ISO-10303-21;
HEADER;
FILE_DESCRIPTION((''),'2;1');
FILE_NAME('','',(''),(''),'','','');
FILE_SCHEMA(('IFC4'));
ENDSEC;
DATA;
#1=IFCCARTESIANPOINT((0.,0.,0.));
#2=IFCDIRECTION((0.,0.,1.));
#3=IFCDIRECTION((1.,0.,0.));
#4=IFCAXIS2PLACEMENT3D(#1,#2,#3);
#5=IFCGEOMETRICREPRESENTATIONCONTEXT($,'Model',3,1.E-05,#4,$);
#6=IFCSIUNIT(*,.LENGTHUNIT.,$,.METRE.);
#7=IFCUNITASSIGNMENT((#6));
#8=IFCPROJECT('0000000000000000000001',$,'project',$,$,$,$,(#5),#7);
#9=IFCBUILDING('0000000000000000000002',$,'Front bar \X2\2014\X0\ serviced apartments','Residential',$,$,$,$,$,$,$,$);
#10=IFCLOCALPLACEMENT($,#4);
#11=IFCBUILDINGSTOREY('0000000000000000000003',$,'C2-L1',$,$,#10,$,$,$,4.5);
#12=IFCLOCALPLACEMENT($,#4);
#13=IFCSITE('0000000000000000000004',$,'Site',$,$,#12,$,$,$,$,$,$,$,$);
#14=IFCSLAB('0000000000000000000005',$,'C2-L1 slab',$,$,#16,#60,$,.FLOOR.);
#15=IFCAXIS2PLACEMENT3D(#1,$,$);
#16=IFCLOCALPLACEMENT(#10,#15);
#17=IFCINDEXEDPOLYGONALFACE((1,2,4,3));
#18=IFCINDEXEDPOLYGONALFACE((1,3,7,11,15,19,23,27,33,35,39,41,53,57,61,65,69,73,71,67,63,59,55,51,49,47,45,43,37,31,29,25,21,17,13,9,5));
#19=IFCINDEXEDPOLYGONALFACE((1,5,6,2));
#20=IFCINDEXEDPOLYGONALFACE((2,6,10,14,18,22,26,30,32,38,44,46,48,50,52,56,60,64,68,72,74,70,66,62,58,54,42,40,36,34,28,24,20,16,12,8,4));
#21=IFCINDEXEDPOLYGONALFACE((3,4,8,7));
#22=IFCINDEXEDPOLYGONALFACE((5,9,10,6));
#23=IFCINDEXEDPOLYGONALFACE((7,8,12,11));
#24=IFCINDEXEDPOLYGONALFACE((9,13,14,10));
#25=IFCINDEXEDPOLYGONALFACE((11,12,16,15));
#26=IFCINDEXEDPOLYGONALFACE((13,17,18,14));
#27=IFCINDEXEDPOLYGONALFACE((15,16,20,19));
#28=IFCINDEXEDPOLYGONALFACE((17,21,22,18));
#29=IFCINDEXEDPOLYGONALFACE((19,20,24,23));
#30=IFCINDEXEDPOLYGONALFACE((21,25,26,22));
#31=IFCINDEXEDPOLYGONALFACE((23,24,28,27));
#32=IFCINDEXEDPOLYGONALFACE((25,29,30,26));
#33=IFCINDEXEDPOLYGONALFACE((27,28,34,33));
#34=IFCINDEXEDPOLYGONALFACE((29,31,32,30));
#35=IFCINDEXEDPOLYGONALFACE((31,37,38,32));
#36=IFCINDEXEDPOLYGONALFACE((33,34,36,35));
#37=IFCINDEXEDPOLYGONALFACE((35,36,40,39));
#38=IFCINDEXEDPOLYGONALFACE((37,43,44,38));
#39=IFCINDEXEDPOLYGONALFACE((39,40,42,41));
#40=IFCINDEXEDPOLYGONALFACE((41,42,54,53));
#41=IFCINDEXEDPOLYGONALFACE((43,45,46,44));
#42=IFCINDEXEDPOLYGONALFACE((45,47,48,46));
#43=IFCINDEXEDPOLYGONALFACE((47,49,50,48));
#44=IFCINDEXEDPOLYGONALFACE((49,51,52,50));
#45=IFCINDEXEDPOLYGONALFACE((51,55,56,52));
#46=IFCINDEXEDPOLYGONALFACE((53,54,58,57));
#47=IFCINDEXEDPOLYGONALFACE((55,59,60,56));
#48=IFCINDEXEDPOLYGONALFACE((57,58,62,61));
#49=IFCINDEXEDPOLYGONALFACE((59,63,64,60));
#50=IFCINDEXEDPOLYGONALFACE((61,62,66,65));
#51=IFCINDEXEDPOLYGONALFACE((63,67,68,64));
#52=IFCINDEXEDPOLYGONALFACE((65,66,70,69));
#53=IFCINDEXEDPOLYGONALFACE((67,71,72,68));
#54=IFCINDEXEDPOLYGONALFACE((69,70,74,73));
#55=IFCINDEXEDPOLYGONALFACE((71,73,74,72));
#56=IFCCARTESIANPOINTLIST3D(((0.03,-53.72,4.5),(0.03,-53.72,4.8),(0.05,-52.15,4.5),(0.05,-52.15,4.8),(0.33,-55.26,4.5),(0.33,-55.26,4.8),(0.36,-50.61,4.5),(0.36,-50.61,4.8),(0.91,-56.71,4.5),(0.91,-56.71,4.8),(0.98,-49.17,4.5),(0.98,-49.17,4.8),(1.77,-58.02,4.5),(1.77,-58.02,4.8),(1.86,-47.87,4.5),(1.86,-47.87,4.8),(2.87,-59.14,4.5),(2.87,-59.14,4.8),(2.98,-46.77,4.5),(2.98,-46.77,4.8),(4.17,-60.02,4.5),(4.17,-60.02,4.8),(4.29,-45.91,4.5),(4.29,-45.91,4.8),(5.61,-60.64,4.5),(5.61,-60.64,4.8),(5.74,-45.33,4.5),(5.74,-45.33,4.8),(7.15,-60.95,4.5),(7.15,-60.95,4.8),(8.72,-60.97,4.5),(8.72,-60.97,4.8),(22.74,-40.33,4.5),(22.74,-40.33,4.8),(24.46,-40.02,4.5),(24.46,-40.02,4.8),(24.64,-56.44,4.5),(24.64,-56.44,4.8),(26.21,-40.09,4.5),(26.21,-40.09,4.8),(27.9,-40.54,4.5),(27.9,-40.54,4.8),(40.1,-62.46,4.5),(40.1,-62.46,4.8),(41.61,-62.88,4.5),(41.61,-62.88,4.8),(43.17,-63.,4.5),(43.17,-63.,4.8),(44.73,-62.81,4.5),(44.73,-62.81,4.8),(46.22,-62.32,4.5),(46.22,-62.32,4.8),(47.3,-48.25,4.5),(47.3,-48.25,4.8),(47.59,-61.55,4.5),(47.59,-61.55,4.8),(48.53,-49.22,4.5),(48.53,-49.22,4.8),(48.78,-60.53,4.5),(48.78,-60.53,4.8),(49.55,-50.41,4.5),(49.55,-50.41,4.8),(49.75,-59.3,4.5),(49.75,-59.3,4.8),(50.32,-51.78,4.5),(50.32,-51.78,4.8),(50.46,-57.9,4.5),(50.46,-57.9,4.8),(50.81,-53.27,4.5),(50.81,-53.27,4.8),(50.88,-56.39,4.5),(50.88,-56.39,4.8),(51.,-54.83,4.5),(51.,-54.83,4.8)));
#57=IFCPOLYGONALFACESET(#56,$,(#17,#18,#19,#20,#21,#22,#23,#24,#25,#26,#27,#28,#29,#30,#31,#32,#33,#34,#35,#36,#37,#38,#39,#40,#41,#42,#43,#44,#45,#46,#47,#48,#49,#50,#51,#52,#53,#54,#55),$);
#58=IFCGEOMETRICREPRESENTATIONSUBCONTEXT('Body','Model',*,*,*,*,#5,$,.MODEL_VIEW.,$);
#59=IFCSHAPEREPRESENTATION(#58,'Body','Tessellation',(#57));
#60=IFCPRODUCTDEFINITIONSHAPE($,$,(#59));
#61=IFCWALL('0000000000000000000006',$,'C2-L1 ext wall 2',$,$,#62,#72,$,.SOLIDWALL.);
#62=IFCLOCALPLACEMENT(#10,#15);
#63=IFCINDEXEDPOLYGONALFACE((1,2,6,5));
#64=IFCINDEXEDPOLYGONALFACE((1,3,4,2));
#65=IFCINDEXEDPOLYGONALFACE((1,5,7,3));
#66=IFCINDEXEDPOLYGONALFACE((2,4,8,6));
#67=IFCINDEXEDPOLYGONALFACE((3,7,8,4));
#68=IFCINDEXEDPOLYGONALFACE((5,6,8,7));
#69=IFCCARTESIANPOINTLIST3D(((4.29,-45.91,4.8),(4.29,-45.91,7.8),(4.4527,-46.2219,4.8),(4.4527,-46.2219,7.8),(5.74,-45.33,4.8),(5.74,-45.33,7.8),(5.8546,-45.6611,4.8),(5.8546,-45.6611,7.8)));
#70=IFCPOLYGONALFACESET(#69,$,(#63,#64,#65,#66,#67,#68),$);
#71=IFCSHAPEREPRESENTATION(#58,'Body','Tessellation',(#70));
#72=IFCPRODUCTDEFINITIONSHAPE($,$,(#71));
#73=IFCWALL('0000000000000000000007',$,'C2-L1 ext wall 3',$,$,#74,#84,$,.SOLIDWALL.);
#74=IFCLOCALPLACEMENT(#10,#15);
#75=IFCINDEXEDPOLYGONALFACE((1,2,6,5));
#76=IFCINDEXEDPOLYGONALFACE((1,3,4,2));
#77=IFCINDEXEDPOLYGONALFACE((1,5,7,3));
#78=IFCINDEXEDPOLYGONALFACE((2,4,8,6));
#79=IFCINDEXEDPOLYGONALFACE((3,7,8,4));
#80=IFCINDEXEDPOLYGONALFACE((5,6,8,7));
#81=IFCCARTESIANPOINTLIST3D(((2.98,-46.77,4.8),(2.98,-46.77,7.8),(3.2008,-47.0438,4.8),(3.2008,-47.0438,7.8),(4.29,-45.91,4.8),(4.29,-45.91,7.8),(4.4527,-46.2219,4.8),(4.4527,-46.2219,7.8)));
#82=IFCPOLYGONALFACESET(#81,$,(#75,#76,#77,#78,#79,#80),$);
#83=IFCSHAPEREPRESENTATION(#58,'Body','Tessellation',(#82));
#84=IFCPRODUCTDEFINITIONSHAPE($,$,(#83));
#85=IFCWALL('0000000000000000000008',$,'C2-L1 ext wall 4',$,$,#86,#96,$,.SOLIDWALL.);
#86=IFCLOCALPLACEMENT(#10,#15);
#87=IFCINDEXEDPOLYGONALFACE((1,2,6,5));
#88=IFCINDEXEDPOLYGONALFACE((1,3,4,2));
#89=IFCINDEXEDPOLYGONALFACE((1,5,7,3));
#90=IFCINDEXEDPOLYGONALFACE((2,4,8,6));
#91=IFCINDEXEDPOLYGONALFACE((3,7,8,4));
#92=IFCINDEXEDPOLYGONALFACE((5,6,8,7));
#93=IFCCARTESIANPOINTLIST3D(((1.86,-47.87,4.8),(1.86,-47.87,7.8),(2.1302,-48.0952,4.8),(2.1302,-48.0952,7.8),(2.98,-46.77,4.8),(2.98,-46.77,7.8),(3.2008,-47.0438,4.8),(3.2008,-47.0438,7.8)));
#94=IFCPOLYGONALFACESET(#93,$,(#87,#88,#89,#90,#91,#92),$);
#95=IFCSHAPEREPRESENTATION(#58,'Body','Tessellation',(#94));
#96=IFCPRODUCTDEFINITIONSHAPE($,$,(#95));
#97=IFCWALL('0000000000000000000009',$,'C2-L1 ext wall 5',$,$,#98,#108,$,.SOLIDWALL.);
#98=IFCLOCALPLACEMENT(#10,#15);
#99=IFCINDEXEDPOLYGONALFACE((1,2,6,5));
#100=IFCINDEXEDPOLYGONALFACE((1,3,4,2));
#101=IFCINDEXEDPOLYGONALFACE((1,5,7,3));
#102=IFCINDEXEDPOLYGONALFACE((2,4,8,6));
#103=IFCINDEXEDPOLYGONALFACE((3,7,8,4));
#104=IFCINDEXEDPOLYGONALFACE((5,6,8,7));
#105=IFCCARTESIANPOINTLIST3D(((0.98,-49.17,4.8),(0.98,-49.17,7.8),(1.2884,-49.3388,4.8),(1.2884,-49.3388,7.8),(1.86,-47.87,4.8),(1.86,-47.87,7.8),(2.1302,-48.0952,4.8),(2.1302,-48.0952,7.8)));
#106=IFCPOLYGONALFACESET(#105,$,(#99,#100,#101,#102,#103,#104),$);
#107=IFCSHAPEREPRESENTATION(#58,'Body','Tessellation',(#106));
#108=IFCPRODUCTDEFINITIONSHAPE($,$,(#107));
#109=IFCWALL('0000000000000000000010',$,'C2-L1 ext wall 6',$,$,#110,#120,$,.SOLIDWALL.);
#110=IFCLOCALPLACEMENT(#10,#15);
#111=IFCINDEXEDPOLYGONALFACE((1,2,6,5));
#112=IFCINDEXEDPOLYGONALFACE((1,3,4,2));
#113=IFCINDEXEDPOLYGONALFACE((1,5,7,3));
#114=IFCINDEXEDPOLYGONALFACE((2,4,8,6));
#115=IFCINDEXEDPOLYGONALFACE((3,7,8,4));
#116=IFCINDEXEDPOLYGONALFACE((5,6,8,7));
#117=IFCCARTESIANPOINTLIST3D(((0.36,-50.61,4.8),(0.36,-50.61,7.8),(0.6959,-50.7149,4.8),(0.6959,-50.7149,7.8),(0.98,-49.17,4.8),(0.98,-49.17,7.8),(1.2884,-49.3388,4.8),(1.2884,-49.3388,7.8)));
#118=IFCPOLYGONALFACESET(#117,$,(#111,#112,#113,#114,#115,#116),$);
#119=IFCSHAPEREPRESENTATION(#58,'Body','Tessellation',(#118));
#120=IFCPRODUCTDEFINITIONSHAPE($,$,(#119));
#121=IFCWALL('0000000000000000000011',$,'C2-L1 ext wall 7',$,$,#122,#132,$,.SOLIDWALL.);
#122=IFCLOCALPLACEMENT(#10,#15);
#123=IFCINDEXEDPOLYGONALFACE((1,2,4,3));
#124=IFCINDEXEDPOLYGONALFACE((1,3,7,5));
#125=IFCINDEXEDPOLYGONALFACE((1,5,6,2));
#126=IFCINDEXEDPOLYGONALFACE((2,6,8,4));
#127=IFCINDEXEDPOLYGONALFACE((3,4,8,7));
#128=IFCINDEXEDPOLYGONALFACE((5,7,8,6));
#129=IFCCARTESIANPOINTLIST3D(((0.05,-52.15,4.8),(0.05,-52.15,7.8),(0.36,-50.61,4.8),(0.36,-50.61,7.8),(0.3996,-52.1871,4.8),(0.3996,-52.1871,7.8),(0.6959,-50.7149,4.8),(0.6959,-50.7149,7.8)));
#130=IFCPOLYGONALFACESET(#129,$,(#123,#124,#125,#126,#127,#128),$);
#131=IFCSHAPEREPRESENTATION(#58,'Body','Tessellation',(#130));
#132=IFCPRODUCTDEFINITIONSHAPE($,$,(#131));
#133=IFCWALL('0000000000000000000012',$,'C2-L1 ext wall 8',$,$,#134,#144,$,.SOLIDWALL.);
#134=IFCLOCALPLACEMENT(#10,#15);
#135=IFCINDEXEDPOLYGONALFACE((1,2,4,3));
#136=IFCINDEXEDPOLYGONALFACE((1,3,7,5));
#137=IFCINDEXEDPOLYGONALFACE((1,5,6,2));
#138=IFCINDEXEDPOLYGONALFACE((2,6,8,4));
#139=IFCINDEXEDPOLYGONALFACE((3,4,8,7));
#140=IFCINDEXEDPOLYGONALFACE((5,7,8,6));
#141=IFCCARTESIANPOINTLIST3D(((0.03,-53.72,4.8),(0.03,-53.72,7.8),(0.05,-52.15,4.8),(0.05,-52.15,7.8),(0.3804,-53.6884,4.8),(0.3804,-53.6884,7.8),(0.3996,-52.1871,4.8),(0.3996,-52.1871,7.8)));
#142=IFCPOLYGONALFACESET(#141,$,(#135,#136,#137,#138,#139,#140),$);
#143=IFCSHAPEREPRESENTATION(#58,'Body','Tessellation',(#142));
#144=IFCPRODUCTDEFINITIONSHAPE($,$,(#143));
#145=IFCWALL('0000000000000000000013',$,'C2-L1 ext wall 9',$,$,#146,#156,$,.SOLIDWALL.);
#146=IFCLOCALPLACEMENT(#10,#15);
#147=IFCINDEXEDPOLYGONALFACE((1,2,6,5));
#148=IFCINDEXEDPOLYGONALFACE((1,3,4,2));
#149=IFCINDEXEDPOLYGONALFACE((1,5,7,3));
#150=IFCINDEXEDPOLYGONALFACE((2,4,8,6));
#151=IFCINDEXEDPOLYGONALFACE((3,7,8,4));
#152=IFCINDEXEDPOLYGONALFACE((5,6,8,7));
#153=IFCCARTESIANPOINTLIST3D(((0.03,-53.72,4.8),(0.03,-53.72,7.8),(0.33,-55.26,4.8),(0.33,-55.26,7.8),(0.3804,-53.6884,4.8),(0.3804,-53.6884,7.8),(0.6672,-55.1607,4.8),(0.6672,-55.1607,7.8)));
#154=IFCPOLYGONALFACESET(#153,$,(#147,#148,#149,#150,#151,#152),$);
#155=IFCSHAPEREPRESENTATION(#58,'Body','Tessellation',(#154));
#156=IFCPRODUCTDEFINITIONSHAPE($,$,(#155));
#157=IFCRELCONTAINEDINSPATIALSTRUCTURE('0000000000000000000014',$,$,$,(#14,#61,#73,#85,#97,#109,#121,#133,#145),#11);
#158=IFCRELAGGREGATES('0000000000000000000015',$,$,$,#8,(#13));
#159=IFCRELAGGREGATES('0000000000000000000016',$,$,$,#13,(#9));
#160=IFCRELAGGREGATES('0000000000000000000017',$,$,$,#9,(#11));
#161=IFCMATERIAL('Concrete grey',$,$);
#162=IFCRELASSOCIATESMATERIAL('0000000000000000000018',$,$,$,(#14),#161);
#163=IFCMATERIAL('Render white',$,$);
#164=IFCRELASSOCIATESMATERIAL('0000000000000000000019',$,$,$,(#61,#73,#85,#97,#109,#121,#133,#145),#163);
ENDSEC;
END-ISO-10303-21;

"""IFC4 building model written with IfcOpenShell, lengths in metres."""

from ifc_helpers import new_model, si_unit, frame, origin_with_axes, place, context, subcontext, project, spatial, polyline, outline, extrude, material, element, save


model = new_model("IFC4")

# Units and contexts
model_context = context("Model", 3, precision=1e-05, world=origin_with_axes())
body_context = subcontext(model_context, "Body", "Model", "MODEL_VIEW")
ifc_project = project(units=[si_unit("LENGTHUNIT", "METRE")], contexts=[model_context])

# Site, building, storey
site_placement = place(None, origin_with_axes())
site = spatial("IfcSite", under=ifc_project, at=site_placement, Name="Site")
building = spatial("IfcBuilding", under=site, Name="Front bar — serviced apartments", Description="Residential")
storey_placement = place(None, origin_with_axes())
storey = spatial("IfcBuildingStorey", under=building, at=storey_placement, Name="C2-L1", Elevation=4.5)

# Slab
ifc_material_1 = material(Name="Concrete grey")
slab_placement = place(storey_placement, origin_with_axes())
element("IfcSlab", 1, at=slab_placement, inside=storey, material=ifc_material_1, Name="C2-L1 slab", PredefinedType="FLOOR", context=body_context, shape_type="SweptSolid", body=[
    extrude(outline(polyline([(22.74, -40.33), (5.74, -45.33), (4.29, -45.91), (2.98, -46.77), (1.86, -47.87), (0.98, -49.17), (0.36, -50.61), (0.05, -52.15), (0.03, -53.72), (0.33, -55.26), (0.91, -56.71), (1.77, -58.02), (2.87, -59.14), (4.17, -60.02), (5.61, -60.64), (7.15, -60.95), (8.72, -60.97), (24.64, -56.44), (40.1, -62.46), (41.61, -62.88), (43.17, -63.0), (44.73, -62.81), (46.22, -62.32), (47.59, -61.55), (48.78, -60.53), (49.75, -59.3), (50.46, -57.9), (50.88, -56.39), (51.0, -54.83), (50.81, -53.27), (50.32, -51.78), (49.55, -50.41), (48.53, -49.22), (47.3, -48.25), (27.9, -40.54), (26.21, -40.09), (24.46, -40.02), (22.74, -40.33)])), frame((0.0, 0.0, 4.5), z_axis=(0.0, 0.0, 1.0), x_axis=(1.0, 0.0, 0.0)), (0.0, 0.0, 1.0), 0.3),
])

# Shared definitions
ifc_material_2 = material(Name="Render white")

# Walls
wall_1_placement = place(storey_placement, origin_with_axes())
element("IfcWall", 2, at=wall_1_placement, inside=storey, material=ifc_material_2, Name="C2-L1 ext wall 2", PredefinedType="SOLIDWALL", context=body_context, shape_type="SweptSolid", body=[
    extrude(outline(polyline([(5.74, -45.33), (4.29, -45.91), (4.4527, -46.2219), (5.8546, -45.6611), (5.74, -45.33)])), frame((0.0, 0.0, 4.8), z_axis=(0.0, 0.0, 1.0), x_axis=(1.0, 0.0, 0.0)), (0.0, 0.0, 1.0), 3.0),
])
wall_2_placement = place(storey_placement, origin_with_axes())
element("IfcWall", 3, at=wall_2_placement, inside=storey, material=ifc_material_2, Name="C2-L1 ext wall 3", PredefinedType="SOLIDWALL", context=body_context, shape_type="SweptSolid", body=[
    extrude(outline(polyline([(4.29, -45.91), (2.98, -46.77), (3.2008, -47.0438), (4.4527, -46.2219), (4.29, -45.91)])), frame((0.0, 0.0, 4.8), z_axis=(0.0, 0.0, 1.0), x_axis=(1.0, 0.0, 0.0)), (0.0, 0.0, 1.0), 3.0),
])
wall_3_placement = place(storey_placement, origin_with_axes())
element("IfcWall", 4, at=wall_3_placement, inside=storey, material=ifc_material_2, Name="C2-L1 ext wall 4", PredefinedType="SOLIDWALL", context=body_context, shape_type="SweptSolid", body=[
    extrude(outline(polyline([(2.98, -46.77), (1.86, -47.87), (2.1302, -48.0952), (3.2008, -47.0438), (2.98, -46.77)])), frame((0.0, 0.0, 4.8), z_axis=(0.0, 0.0, 1.0), x_axis=(1.0, 0.0, 0.0)), (0.0, 0.0, 1.0), 3.0),
])
wall_4_placement = place(storey_placement, origin_with_axes())
element("IfcWall", 5, at=wall_4_placement, inside=storey, material=ifc_material_2, Name="C2-L1 ext wall 5", PredefinedType="SOLIDWALL", context=body_context, shape_type="SweptSolid", body=[
    extrude(outline(polyline([(1.86, -47.87), (0.98, -49.17), (1.2884, -49.3388), (2.1302, -48.0952), (1.86, -47.87)])), frame((0.0, 0.0, 4.8), z_axis=(0.0, 0.0, 1.0), x_axis=(1.0, 0.0, 0.0)), (0.0, 0.0, 1.0), 3.0),
])
wall_5_placement = place(storey_placement, origin_with_axes())
element("IfcWall", 6, at=wall_5_placement, inside=storey, material=ifc_material_2, Name="C2-L1 ext wall 6", PredefinedType="SOLIDWALL", context=body_context, shape_type="SweptSolid", body=[
    extrude(outline(polyline([(0.98, -49.17), (0.36, -50.61), (0.6959, -50.7149), (1.2884, -49.3388), (0.98, -49.17)])), frame((0.0, 0.0, 4.8), z_axis=(0.0, 0.0, 1.0), x_axis=(1.0, 0.0, 0.0)), (0.0, 0.0, 1.0), 3.0),
])
wall_6_placement = place(storey_placement, origin_with_axes())
element("IfcWall", 7, at=wall_6_placement, inside=storey, material=ifc_material_2, Name="C2-L1 ext wall 7", PredefinedType="SOLIDWALL", context=body_context, shape_type="SweptSolid", body=[
    extrude(outline(polyline([(0.36, -50.61), (0.05, -52.15), (0.3996, -52.1871), (0.6959, -50.7149), (0.36, -50.61)])), frame((0.0, 0.0, 4.8), z_axis=(0.0, 0.0, 1.0), x_axis=(1.0, 0.0, 0.0)), (0.0, 0.0, 1.0), 3.0),
])
wall_7_placement = place(storey_placement, origin_with_axes())
element("IfcWall", 8, at=wall_7_placement, inside=storey, material=ifc_material_2, Name="C2-L1 ext wall 8", PredefinedType="SOLIDWALL", context=body_context, shape_type="SweptSolid", body=[
    extrude(outline(polyline([(0.05, -52.15), (0.03, -53.72), (0.3804, -53.6884), (0.3996, -52.1871), (0.05, -52.15)])), frame((0.0, 0.0, 4.8), z_axis=(0.0, 0.0, 1.0), x_axis=(1.0, 0.0, 0.0)), (0.0, 0.0, 1.0), 3.0),
])
wall_8_placement = place(storey_placement, origin_with_axes())
element("IfcWall", 9, at=wall_8_placement, inside=storey, material=ifc_material_2, Name="C2-L1 ext wall 9", PredefinedType="SOLIDWALL", context=body_context, shape_type="SweptSolid", body=[
    extrude(outline(polyline([(0.03, -53.72), (0.33, -55.26), (0.6672, -55.1607), (0.3804, -53.6884), (0.03, -53.72)])), frame((0.0, 0.0, 4.8), z_axis=(0.0, 0.0, 1.0), x_axis=(1.0, 0.0, 0.0)), (0.0, 0.0, 1.0), 3.0),
])

save(model, "model.ifc")
